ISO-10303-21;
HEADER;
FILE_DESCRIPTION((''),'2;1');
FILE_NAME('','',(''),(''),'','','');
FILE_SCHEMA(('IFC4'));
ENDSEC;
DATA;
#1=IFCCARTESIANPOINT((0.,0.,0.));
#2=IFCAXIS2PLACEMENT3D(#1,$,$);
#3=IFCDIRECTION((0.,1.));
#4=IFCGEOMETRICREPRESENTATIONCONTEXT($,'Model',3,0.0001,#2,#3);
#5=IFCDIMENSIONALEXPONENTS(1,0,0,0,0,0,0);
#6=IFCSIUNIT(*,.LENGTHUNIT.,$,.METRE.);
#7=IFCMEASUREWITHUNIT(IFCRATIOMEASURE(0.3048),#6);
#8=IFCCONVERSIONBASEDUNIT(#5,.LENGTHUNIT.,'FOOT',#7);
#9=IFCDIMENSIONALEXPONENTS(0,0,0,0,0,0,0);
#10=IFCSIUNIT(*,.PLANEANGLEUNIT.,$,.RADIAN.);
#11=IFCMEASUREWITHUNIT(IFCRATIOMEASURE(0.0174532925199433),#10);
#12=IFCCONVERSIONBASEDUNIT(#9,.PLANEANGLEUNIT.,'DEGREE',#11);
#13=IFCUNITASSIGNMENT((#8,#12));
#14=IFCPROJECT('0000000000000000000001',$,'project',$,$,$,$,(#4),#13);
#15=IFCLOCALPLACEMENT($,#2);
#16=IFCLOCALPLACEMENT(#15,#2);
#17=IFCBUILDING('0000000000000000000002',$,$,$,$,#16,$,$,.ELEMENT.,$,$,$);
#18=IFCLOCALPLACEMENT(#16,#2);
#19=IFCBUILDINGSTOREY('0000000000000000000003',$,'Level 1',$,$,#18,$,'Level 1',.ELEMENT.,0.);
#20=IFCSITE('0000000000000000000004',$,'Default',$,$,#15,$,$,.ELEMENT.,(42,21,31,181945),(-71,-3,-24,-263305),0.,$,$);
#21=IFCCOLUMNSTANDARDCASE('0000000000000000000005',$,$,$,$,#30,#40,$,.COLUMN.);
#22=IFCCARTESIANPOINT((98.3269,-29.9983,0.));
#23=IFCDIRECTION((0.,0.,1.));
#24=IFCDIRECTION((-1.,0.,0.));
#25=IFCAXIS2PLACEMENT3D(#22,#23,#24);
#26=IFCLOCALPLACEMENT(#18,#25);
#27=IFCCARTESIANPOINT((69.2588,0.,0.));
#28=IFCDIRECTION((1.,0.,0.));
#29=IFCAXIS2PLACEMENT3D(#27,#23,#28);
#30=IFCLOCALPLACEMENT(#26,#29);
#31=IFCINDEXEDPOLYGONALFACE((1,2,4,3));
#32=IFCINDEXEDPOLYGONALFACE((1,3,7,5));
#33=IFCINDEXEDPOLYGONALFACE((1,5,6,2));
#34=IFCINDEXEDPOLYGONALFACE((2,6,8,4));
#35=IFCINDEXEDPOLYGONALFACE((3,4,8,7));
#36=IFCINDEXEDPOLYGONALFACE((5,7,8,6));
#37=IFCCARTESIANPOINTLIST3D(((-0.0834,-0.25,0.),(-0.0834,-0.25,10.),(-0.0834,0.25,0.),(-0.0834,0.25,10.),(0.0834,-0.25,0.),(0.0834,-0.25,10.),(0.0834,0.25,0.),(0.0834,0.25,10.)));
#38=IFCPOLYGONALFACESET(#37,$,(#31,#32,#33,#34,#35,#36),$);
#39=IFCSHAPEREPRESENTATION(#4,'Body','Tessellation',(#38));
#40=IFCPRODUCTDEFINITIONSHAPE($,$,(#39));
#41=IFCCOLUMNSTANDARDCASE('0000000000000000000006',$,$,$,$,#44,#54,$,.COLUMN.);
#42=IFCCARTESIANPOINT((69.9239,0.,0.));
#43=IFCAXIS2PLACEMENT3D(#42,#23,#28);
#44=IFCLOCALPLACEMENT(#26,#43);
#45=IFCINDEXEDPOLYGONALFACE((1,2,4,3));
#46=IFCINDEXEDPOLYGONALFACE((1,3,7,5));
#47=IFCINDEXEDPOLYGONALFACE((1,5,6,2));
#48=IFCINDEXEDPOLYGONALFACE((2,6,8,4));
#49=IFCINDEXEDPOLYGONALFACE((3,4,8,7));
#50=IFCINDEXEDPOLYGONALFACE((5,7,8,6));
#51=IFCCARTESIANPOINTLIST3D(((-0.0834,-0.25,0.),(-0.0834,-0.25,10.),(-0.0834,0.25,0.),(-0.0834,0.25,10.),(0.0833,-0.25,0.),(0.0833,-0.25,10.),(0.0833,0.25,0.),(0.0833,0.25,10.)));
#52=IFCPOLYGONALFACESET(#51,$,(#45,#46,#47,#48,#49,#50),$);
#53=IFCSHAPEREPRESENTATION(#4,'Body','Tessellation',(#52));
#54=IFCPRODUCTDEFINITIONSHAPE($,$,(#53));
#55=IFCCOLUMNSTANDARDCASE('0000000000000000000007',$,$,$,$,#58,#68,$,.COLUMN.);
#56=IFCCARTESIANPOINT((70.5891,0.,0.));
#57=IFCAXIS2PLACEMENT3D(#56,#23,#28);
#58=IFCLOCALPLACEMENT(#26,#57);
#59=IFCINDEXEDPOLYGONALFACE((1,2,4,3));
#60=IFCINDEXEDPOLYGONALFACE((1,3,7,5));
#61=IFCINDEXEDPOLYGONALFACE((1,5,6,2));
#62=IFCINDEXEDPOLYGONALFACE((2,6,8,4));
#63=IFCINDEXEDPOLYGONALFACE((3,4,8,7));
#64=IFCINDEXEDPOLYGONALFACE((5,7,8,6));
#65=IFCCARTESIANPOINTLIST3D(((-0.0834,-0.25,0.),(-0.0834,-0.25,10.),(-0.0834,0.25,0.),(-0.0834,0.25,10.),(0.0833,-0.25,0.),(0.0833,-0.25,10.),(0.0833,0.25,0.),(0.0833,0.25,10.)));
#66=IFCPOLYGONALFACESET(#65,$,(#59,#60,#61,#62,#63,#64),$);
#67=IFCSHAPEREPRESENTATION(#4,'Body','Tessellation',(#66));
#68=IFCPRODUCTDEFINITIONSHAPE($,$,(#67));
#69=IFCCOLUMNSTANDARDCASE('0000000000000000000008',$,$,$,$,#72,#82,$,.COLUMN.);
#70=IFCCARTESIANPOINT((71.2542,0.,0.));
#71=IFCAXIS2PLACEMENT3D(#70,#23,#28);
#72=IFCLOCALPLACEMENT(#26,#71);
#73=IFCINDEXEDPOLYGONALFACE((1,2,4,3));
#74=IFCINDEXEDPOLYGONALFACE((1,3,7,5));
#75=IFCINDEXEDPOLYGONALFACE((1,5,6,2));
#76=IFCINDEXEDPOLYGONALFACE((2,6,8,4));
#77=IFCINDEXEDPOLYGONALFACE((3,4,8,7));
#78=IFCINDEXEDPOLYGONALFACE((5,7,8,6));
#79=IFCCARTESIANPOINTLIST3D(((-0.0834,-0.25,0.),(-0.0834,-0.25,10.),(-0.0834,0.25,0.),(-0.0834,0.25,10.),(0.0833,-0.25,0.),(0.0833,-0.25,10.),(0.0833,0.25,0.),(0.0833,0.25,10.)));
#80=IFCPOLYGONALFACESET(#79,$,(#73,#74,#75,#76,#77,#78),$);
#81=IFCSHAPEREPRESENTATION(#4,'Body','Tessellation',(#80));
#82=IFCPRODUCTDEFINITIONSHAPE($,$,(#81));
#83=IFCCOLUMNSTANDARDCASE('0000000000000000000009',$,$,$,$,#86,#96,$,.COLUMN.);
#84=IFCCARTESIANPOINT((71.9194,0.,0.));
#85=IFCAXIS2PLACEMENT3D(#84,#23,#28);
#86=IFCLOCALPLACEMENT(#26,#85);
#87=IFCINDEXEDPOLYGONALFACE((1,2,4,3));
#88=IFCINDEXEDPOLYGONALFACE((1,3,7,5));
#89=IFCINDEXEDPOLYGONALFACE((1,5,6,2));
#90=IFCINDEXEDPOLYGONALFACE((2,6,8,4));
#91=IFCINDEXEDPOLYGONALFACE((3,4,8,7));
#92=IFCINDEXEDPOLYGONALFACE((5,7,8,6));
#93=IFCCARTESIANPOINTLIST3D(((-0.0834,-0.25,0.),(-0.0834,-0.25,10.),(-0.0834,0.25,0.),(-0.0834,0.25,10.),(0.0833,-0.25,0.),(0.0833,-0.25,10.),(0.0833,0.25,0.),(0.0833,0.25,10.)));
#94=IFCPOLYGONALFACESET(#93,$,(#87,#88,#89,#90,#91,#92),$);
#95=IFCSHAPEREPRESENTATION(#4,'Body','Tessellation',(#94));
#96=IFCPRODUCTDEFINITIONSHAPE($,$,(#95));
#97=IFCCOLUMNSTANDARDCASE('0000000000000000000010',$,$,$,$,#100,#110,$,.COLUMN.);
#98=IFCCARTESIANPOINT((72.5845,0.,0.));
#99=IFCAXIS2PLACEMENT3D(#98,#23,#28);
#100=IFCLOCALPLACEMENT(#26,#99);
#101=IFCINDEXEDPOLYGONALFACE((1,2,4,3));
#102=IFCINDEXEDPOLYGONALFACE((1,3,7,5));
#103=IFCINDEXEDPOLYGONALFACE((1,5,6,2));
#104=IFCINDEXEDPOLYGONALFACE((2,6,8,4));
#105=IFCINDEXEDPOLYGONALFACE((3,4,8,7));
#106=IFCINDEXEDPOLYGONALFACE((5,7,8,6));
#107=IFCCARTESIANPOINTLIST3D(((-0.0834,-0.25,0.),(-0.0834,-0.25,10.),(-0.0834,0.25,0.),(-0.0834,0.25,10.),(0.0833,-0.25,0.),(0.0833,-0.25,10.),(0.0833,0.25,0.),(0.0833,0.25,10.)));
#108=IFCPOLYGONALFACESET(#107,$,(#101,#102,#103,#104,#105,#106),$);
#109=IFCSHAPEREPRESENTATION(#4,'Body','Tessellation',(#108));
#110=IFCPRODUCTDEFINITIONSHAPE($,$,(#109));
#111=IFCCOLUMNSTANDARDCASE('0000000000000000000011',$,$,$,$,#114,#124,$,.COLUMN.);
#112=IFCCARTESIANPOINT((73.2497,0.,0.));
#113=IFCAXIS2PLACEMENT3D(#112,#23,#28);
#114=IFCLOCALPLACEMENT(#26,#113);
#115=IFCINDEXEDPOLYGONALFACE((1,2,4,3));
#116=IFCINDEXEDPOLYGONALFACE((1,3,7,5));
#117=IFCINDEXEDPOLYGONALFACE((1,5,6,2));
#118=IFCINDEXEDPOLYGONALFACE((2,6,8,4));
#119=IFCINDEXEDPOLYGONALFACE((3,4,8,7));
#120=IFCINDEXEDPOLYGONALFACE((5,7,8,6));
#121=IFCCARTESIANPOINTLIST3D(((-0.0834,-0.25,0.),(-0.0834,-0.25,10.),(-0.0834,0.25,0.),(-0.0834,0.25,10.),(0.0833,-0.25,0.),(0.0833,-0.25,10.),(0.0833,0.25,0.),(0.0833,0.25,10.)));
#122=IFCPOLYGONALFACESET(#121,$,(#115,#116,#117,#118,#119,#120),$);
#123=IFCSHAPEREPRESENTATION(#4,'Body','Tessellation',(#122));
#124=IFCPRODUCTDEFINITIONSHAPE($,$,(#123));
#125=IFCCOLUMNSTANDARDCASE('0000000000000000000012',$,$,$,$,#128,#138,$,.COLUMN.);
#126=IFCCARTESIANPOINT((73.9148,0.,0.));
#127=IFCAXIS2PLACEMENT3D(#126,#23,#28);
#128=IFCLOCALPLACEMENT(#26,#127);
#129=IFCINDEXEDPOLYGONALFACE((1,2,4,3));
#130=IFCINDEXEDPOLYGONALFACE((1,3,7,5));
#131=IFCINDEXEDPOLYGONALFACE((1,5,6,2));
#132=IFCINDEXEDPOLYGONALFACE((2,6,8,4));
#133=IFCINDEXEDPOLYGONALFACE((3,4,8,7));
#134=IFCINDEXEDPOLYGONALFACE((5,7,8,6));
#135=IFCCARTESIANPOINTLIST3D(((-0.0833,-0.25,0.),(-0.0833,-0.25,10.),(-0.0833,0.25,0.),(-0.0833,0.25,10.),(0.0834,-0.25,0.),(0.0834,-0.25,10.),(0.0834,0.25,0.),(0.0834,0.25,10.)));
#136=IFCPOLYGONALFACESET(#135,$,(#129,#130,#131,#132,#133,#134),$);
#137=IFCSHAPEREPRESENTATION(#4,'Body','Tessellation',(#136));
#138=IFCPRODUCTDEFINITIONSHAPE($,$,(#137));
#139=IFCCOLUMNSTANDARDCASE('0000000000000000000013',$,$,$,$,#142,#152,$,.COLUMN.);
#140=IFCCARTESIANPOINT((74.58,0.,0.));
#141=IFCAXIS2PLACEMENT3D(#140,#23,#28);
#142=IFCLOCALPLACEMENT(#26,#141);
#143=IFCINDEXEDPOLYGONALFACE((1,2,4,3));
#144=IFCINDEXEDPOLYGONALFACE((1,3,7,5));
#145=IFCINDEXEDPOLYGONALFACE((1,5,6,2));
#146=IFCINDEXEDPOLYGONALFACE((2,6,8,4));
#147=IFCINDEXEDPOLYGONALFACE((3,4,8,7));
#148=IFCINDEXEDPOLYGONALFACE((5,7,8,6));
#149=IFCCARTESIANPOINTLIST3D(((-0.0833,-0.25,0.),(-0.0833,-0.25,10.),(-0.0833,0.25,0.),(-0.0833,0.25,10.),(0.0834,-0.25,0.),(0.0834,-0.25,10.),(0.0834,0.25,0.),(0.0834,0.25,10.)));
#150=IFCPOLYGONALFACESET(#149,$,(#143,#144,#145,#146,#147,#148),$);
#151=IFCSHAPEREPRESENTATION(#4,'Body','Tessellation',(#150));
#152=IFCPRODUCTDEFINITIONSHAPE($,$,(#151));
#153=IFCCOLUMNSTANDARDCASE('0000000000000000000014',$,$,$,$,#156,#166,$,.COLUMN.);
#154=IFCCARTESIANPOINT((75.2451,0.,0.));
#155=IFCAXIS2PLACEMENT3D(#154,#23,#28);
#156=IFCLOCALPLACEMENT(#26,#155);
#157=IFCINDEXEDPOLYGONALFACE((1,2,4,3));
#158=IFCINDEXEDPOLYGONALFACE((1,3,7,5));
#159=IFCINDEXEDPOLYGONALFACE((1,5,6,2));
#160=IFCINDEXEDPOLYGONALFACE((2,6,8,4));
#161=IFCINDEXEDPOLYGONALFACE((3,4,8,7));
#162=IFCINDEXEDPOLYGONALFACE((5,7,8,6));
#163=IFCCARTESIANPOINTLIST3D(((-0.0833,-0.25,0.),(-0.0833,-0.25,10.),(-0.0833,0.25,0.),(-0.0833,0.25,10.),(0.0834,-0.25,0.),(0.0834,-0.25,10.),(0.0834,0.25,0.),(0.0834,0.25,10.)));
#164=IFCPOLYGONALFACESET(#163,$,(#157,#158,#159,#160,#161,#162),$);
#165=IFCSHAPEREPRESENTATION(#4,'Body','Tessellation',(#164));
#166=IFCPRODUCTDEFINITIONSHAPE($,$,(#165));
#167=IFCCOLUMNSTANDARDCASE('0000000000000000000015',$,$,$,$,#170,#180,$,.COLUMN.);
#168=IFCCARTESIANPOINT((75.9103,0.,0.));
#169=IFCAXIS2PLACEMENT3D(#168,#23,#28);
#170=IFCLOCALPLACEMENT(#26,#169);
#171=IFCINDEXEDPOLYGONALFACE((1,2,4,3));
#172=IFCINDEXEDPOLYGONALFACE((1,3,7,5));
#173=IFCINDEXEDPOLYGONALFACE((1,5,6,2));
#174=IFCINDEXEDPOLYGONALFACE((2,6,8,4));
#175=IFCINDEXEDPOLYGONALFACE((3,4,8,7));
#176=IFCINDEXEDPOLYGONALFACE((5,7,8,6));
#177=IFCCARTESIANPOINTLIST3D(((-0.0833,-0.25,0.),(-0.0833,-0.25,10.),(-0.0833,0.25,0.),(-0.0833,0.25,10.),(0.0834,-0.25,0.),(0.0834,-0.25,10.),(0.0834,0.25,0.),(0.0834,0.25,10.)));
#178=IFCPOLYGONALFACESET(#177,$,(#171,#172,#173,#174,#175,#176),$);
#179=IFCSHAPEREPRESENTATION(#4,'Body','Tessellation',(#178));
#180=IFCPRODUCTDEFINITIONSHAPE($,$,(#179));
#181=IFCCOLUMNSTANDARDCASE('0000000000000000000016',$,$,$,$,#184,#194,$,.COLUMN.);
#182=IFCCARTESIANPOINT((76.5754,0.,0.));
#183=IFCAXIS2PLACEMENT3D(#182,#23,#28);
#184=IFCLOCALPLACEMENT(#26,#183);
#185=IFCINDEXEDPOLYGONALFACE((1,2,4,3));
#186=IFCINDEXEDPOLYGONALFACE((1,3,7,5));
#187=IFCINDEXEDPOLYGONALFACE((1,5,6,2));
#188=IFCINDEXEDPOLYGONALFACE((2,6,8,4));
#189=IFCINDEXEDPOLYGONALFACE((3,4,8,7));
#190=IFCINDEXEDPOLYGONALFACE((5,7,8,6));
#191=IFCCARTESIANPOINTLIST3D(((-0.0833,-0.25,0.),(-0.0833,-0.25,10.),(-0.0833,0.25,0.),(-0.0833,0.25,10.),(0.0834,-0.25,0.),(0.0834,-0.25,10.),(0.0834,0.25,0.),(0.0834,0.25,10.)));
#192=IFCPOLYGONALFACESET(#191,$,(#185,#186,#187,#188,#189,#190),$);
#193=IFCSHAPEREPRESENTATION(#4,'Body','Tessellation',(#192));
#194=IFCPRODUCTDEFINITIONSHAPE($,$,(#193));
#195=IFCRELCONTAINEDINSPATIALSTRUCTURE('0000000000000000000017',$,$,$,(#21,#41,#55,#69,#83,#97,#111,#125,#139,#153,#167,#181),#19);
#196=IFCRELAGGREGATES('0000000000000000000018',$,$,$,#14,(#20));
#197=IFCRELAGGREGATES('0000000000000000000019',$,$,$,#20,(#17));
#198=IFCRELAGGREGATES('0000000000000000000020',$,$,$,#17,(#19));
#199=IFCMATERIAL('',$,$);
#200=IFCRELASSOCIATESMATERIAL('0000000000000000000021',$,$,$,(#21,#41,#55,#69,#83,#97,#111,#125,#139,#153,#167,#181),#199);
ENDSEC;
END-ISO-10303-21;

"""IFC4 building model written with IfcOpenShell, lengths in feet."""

from ifc_helpers import new_model, entity, si_unit, converted_unit, direction, frame, origin, place, context, project, spatial, rectangle, extrude, material, element, save


model = new_model("IFC4")

# Units and contexts
model_context = context("Model", 3, precision=0.0001, world=origin(), true_north=direction((0.0, 1.0)))
ifc_project = project(units=[converted_unit("LENGTHUNIT", "FOOT", entity("IfcRatioMeasure", 0.3048), si_unit("LENGTHUNIT", "METRE"), dimensions=[1, 0, 0, 0, 0, 0, 0]), converted_unit("PLANEANGLEUNIT", "DEGREE", entity("IfcRatioMeasure", 0.0174532925199433), si_unit("PLANEANGLEUNIT", "RADIAN"), dimensions=[0, 0, 0, 0, 0, 0, 0])], contexts=[model_context])

# Site, building, storey
site_placement = place(None, origin())
site = spatial("IfcSite", under=ifc_project, at=site_placement, Name="Default", CompositionType="ELEMENT", RefLatitude=(42, 21, 31, 181945), RefLongitude=(-71, -3, -24, -263305), RefElevation=0.0)
building_placement = place(site_placement, origin())
building = spatial("IfcBuilding", under=site, at=building_placement, CompositionType="ELEMENT")
storey_placement = place(building_placement, origin())
storey = spatial("IfcBuildingStorey", under=building, at=storey_placement, Name="Level 1", LongName="Level 1", CompositionType="ELEMENT", Elevation=0.0)

# Columns
ifc_material = material(Name="")
placement = place(storey_placement, frame((98.3269, -29.9983, 0.0), z_axis=(0.0, 0.0, 1.0), x_axis=(-1.0, 0.0, 0.0)))
for number, where, z_axis, x_axis in (
    (1, (69.2588, 0.0, 0.0), (0.0, 0.0, 1.0), (1.0, 0.0, 0.0)),
    (2, (69.9239, 0.0, 0.0), (0.0, 0.0, 1.0), (1.0, 0.0, 0.0)),
    (3, (70.5891, 0.0, 0.0), (0.0, 0.0, 1.0), (1.0, 0.0, 0.0)),
    (4, (71.2542, 0.0, 0.0), (0.0, 0.0, 1.0), (1.0, 0.0, 0.0)),
    (5, (71.9194, 0.0, 0.0), (0.0, 0.0, 1.0), (1.0, 0.0, 0.0)),
    (6, (72.5845, 0.0, 0.0), (0.0, 0.0, 1.0), (1.0, 0.0, 0.0)),
    (7, (73.2497, 0.0, 0.0), (0.0, 0.0, 1.0), (1.0, 0.0, 0.0)),
    (8, (73.9148, 0.0, 0.0), (0.0, 0.0, 1.0), (1.0, 0.0, 0.0)),
    (9, (74.58, 0.0, 0.0), (0.0, 0.0, 1.0), (1.0, 0.0, 0.0)),
    (10, (75.2451, 0.0, 0.0), (0.0, 0.0, 1.0), (1.0, 0.0, 0.0)),
    (11, (75.9103, 0.0, 0.0), (0.0, 0.0, 1.0), (1.0, 0.0, 0.0)),
    (12, (76.5754, 0.0, 0.0), (0.0, 0.0, 1.0), (1.0, 0.0, 0.0)),
):
    element("IfcColumnStandardCase", number, at=place(placement, frame(where, z_axis=z_axis, x_axis=x_axis)), inside=storey, material=ifc_material, PredefinedType="COLUMN", context=model_context, shape_type="SweptSolid", body=[
        extrude(rectangle(XDim=0.1667, YDim=0.5), origin(), (0.0, 0.0, 1.0), 10.0),
    ])

save(model, "model.ifc")
